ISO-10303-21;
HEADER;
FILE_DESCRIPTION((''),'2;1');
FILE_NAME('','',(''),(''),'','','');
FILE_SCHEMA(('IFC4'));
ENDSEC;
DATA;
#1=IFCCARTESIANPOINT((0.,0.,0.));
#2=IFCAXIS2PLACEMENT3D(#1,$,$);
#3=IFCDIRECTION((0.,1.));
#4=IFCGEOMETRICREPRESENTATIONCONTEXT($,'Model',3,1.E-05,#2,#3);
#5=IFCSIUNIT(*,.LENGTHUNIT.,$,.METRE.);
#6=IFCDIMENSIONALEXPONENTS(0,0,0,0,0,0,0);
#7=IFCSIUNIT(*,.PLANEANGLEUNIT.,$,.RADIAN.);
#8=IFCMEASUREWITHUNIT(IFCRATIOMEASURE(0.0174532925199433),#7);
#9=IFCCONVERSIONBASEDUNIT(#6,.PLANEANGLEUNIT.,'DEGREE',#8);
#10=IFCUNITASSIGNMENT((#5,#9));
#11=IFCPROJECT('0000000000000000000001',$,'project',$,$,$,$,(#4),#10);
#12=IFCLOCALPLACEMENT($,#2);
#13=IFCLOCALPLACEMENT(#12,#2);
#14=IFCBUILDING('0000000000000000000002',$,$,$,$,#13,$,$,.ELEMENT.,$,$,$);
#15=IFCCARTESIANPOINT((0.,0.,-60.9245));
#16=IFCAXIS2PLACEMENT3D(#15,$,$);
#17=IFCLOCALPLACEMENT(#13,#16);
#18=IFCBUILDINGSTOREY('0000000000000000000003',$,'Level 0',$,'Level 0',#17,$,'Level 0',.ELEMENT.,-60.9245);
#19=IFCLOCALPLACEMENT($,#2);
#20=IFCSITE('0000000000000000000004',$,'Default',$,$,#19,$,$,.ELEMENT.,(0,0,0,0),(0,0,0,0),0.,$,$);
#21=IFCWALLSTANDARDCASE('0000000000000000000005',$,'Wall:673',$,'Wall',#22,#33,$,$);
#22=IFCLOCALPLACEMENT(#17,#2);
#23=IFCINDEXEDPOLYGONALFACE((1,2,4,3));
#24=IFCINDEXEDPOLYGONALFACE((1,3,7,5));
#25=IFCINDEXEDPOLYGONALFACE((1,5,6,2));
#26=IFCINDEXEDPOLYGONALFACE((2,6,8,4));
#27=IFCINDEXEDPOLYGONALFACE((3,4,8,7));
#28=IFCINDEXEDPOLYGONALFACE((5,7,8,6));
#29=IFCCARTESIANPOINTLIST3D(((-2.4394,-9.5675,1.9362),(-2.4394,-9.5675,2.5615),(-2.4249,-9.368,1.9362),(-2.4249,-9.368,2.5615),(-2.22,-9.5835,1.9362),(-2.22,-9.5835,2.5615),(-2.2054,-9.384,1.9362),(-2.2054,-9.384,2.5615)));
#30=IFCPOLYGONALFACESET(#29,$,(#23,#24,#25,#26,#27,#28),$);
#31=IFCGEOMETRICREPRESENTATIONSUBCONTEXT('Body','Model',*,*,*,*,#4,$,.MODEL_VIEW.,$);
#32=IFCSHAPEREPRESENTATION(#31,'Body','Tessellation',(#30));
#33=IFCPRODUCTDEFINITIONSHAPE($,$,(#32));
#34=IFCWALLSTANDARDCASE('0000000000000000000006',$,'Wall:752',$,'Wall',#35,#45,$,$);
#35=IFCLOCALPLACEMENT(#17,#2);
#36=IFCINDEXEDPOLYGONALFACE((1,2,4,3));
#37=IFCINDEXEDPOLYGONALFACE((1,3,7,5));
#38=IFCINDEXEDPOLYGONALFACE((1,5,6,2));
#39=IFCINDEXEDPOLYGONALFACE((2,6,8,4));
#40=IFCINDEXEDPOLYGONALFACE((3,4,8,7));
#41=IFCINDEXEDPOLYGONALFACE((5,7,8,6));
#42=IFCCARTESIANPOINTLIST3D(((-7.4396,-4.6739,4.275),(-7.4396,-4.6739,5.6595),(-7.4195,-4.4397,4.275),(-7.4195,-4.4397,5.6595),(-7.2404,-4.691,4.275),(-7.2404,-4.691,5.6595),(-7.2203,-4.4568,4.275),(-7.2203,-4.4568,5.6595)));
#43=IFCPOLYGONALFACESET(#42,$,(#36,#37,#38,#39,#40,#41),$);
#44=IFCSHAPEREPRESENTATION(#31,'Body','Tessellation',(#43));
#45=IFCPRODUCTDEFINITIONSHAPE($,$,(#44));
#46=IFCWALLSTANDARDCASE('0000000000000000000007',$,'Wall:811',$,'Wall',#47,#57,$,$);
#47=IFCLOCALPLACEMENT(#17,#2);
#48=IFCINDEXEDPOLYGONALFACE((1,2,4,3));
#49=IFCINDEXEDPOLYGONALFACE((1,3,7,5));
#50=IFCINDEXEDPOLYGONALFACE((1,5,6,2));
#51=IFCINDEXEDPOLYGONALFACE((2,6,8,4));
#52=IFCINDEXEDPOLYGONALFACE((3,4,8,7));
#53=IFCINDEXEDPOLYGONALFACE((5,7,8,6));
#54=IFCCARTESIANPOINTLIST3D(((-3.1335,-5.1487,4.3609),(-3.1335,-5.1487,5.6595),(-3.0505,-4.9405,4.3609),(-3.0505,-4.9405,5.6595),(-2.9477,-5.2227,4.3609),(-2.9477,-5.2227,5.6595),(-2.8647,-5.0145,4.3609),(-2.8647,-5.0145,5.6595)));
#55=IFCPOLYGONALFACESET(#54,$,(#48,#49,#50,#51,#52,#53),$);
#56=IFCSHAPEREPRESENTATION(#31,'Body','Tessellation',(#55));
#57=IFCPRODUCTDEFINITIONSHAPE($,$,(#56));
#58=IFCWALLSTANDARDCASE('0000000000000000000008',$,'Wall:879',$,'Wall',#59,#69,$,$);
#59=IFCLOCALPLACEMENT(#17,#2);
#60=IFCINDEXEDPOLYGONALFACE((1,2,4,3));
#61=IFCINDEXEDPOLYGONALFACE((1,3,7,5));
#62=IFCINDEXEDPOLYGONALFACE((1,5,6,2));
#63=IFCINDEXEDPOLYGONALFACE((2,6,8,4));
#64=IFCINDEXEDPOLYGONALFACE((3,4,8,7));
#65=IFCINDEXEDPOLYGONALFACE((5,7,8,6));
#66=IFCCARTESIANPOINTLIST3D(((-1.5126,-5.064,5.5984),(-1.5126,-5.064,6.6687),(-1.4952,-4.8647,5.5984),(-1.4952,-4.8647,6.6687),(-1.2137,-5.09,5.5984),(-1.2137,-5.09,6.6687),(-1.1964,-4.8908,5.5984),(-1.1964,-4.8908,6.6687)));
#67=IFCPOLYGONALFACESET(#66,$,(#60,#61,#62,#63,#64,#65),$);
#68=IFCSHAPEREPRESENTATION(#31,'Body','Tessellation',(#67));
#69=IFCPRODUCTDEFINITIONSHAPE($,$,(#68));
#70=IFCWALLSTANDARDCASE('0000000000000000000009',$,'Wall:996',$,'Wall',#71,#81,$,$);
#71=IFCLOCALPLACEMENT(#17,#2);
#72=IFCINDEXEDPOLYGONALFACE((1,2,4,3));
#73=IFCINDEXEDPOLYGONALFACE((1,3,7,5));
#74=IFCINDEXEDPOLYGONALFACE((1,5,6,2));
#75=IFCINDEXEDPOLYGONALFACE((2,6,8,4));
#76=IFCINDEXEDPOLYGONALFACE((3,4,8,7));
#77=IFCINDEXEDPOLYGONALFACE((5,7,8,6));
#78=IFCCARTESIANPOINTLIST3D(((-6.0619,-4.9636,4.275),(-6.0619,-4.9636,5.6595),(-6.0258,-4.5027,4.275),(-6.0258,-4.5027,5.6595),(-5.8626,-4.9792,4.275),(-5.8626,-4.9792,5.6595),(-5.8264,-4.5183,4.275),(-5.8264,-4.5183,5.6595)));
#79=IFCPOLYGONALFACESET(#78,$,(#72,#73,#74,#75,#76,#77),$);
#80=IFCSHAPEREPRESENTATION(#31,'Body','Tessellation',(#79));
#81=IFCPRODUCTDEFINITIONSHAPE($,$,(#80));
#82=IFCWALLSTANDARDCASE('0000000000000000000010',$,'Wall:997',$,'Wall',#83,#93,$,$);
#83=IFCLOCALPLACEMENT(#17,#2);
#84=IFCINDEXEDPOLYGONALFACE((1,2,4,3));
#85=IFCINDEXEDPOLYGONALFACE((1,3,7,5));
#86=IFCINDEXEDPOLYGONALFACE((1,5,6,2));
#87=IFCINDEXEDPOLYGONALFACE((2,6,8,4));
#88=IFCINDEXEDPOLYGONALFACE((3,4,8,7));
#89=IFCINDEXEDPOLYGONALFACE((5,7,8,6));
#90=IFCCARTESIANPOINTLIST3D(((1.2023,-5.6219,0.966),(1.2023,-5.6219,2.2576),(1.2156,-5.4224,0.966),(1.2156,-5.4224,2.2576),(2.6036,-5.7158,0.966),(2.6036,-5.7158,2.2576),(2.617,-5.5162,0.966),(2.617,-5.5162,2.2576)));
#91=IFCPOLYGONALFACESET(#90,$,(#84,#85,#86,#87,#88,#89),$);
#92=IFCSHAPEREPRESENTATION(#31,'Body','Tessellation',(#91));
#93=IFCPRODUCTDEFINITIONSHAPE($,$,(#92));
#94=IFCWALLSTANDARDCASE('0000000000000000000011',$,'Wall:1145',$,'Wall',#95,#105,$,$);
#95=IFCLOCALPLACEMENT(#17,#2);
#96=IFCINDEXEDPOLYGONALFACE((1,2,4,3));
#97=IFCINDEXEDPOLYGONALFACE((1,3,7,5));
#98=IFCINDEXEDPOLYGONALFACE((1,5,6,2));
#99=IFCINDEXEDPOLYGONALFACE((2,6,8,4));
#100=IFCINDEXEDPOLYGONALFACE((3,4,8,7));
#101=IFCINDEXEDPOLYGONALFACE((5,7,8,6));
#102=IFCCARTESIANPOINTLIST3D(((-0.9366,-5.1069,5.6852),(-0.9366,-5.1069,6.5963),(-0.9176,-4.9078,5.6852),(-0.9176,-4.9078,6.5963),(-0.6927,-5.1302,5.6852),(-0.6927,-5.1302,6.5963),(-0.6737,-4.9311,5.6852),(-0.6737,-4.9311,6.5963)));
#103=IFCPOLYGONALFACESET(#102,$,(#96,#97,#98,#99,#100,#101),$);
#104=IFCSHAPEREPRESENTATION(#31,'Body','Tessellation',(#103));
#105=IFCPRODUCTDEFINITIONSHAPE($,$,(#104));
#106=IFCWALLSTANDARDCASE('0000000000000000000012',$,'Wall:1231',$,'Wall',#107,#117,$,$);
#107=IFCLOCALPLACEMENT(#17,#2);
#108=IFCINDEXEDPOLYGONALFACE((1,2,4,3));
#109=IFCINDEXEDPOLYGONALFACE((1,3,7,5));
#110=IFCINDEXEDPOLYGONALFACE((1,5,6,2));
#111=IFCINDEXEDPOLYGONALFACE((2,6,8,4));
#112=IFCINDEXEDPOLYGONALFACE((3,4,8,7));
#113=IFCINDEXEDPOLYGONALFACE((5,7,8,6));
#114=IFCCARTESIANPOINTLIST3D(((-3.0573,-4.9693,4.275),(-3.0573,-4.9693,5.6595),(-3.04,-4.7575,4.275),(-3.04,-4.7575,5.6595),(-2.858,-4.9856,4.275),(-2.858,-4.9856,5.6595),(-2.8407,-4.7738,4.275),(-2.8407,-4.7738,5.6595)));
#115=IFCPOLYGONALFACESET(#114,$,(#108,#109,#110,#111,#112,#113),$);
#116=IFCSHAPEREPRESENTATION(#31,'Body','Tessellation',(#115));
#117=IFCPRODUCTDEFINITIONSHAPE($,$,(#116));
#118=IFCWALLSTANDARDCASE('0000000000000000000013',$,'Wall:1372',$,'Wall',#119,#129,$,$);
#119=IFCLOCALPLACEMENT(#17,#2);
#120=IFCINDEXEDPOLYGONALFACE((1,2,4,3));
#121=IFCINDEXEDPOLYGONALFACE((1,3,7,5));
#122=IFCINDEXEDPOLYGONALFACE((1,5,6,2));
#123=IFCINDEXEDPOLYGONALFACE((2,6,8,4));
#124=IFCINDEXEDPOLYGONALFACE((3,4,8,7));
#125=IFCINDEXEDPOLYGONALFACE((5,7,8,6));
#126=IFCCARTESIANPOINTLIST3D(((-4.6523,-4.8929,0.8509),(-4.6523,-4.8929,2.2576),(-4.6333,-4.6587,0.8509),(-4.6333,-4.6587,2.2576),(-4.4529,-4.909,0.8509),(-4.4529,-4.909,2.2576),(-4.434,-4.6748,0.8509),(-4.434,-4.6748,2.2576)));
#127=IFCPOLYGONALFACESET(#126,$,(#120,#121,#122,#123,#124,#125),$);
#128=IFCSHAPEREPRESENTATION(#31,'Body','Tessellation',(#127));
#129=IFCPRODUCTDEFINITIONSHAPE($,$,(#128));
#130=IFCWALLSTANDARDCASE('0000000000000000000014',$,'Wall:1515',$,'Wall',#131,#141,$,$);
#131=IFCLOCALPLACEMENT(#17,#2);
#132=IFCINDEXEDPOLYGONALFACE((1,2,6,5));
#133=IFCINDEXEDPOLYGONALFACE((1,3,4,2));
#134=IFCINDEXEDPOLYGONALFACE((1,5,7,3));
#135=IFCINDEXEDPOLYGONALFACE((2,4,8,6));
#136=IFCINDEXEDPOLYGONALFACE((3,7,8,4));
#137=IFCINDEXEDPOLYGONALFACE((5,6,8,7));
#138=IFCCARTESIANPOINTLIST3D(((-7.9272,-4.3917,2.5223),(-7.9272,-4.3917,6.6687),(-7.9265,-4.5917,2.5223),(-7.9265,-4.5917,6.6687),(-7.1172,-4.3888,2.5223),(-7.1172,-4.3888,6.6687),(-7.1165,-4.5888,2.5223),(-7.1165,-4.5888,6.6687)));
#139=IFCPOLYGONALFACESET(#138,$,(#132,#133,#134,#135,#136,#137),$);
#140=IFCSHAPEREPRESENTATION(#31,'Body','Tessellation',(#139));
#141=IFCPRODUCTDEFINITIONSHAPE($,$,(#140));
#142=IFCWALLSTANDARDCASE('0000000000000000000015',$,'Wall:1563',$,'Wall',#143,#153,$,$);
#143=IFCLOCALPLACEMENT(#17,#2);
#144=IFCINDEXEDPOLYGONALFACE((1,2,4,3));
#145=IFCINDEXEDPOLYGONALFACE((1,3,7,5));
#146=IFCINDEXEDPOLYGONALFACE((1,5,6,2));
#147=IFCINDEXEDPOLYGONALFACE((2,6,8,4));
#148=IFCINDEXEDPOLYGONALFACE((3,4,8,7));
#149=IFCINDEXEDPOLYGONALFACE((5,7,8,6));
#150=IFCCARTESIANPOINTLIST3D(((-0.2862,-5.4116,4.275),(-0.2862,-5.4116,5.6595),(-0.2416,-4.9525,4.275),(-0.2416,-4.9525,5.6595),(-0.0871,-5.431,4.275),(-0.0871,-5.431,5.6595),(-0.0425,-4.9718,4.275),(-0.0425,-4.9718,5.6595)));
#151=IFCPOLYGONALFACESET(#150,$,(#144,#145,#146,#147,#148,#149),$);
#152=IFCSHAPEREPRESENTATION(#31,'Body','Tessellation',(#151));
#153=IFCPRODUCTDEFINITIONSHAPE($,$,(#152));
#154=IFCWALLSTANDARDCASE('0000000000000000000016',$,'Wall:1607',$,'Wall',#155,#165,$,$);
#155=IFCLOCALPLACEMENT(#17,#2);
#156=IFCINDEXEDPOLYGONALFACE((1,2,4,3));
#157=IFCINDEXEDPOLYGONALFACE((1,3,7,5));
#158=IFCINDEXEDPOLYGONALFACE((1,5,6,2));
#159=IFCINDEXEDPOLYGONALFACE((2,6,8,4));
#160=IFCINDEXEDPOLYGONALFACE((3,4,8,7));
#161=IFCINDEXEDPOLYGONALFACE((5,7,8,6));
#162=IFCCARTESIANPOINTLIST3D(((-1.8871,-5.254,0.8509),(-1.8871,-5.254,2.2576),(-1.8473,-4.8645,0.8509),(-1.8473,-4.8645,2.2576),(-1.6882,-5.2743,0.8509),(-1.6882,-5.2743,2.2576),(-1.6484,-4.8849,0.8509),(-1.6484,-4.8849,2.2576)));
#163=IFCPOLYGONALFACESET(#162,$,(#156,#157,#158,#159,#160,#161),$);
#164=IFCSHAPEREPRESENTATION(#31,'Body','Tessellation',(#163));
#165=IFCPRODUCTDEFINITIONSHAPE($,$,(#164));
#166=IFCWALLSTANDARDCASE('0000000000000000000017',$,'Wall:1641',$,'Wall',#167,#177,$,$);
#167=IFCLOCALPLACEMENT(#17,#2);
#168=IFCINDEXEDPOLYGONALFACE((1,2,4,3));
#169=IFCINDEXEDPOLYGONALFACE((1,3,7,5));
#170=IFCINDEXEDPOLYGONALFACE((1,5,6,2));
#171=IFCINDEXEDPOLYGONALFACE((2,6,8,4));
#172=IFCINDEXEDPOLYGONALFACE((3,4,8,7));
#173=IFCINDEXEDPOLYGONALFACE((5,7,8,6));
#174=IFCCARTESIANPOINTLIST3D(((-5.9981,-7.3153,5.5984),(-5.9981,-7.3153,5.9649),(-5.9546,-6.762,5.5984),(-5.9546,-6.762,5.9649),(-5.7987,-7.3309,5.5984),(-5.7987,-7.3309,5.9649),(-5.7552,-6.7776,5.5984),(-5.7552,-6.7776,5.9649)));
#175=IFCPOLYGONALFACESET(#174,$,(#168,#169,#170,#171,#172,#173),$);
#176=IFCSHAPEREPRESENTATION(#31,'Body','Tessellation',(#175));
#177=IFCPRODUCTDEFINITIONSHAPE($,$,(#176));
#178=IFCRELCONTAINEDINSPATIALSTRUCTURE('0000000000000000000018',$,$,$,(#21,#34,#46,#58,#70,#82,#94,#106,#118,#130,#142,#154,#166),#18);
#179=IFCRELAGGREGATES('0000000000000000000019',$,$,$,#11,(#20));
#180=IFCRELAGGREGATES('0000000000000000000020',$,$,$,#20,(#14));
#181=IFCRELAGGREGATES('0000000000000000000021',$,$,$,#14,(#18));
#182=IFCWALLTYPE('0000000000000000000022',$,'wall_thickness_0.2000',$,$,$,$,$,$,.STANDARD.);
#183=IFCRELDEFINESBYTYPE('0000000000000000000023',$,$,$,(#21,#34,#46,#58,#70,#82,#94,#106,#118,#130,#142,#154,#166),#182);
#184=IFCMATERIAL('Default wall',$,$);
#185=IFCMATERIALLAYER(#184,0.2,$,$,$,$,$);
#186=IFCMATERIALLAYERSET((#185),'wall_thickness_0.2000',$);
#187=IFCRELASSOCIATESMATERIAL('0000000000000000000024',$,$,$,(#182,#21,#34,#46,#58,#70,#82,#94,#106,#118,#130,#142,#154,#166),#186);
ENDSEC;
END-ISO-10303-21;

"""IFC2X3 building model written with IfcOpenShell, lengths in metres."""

from ifc_helpers import new_model, entity, si_unit, converted_unit, direction, frame, origin, place, context, subcontext, project, spatial, polyline, outline, extrude, material, layer, layer_set, layer_usage, type_object, element, save


model = new_model("IFC2X3")

# Units and contexts
model_context = context("Model", 3, precision=1e-05, world=origin(), true_north=direction((0.0, 1.0)))
body_context = subcontext(model_context, "Body", "Model", "MODEL_VIEW")
ifc_project = project(units=[si_unit("LENGTHUNIT", "METRE"), converted_unit("PLANEANGLEUNIT", "DEGREE", entity("IfcRatioMeasure", 0.0174532925199433), si_unit("PLANEANGLEUNIT", "RADIAN"), dimensions=[0, 0, 0, 0, 0, 0, 0])], contexts=[model_context])

# Site, building, storey
site_placement = place(None, origin())
site = spatial("IfcSite", under=ifc_project, at=site_placement, Name="Default", CompositionType="ELEMENT", RefLatitude=(0, 0, 0, 0), RefLongitude=(0, 0, 0, 0), RefElevation=0.0)
placement_1 = place(None, origin())
building_placement = place(placement_1, origin())
building = spatial("IfcBuilding", under=site, at=building_placement, CompositionType="ELEMENT")
storey_placement = place(building_placement, frame((0.0, 0.0, -60.9245)))
storey = spatial("IfcBuildingStorey", under=building, at=storey_placement, Name="Level 0", ObjectType="Level 0", LongName="Level 0", CompositionType="ELEMENT", Elevation=-60.9245)

# Shared definitions
ifc_material_1 = material(Name="Default wall")
ifc_layer = layer(ifc_material_1, 0.2)
ifc_layer_set = layer_set([ifc_layer], Name="wall_thickness_0.2000")
ifc_layer_usage = layer_usage(ifc_layer_set, "AXIS2", "POSITIVE", -0.1)
wall_type = type_object("IfcWallType", Name="wall_thickness_0.2000", PredefinedType="STANDARD", material=ifc_layer_set)

# Walls
placement_2 = place(building_placement, frame((0.0, 0.0, -58.9883)))
wall_1_placement = place(placement_2, frame((-2.2127, -9.4838, 0.0), z_axis=(0.0, 0.0, 1.0), x_axis=(-0.997357, 0.072661, 0.0)))
element("IfcWallStandardCase", 1, at=wall_1_placement, inside=storey, type_object=wall_type, material=ifc_layer_usage, Name="Wall:673", ObjectType="Wall", context=body_context, shape_type="SweptSolid", body=[
    extrude(outline(polyline([(0.22, -0.1), (0.22, 0.1), (0.0, 0.1), (0.0, -0.1), (0.22, -0.1)])), origin(), (0.0, 0.0, 1.0), 0.6253),
])
placement_3 = place(building_placement, frame((0.0, 0.0, -56.6495)))
wall_2_placement = place(placement_3, frame((-7.3199, -4.4483, 0.0), z_axis=(0.0, 0.0, 1.0), x_axis=(-0.085445, -0.996343, 0.0)))
element("IfcWallStandardCase", 2, at=wall_2_placement, inside=storey, type_object=wall_type, material=ifc_layer_usage, Name="Wall:752", ObjectType="Wall", context=body_context, shape_type="SweptSolid", body=[
    extrude(outline(polyline([(0.235, -0.1), (0.235, 0.1), (0.0, 0.1), (0.0, -0.1), (0.235, -0.1)])), origin(), (0.0, 0.0, 1.0), 1.3845),
])
placement_4 = place(building_placement, frame((0.0, 0.0, -56.5636)))
wall_3_placement = place(placement_4, frame((-3.0406, -5.1857, 0.0), z_axis=(0.0, 0.0, 1.0), x_axis=(0.370155, 0.92897, 0.0)))
element("IfcWallStandardCase", 3, at=wall_3_placement, inside=storey, type_object=wall_type, material=ifc_layer_usage, Name="Wall:811", ObjectType="Wall", context=body_context, shape_type="SweptSolid", body=[
    extrude(outline(polyline([(0.2241, -0.1), (0.2241, 0.1), (0.0, 0.1), (0.0, -0.1), (0.2241, -0.1)])), origin(), (0.0, 0.0, 1.0), 1.2985),
])
placement_5 = place(building_placement, frame((0.0, 0.0, -55.3261)))
wall_4_placement = place(placement_5, frame((-1.205, -4.9904, 0.0), z_axis=(0.0, 0.0, 1.0), x_axis=(-0.996227, 0.086791, 0.0)))
element("IfcWallStandardCase", 4, at=wall_4_placement, inside=storey, type_object=wall_type, material=ifc_layer_usage, Name="Wall:879", ObjectType="Wall", context=body_context, shape_type="SweptSolid", body=[
    extrude(outline(polyline([(0.3, -0.1), (0.3, 0.1), (0.0, 0.1), (0.0, -0.1), (0.3, -0.1)])), origin(), (0.0, 0.0, 1.0), 1.0703),
])
placement_6 = place(building_placement, frame((0.0, 0.0, -56.6495)))
wall_5_placement = place(placement_6, frame((-5.9261, -4.5105, 0.0), z_axis=(0.0, 0.0, 1.0), x_axis=(-0.078166, -0.99694, 0.0)))
element("IfcWallStandardCase", 5, at=wall_5_placement, inside=storey, type_object=wall_type, material=ifc_layer_usage, Name="Wall:996", ObjectType="Wall", context=body_context, shape_type="SweptSolid", body=[
    extrude(outline(polyline([(0.4623, -0.1), (0.4623, 0.1), (0.0, 0.1), (0.0, -0.1), (0.4623, -0.1)])), origin(), (0.0, 0.0, 1.0), 1.3845),
])
placement_7 = place(building_placement, frame((0.0, 0.0, -59.9585)))
wall_6_placement = place(placement_7, frame((2.6103, -5.616, 0.0), z_axis=(0.0, 0.0, 1.0), x_axis=(-0.997764, 0.066831, 0.0)))
element("IfcWallStandardCase", 6, at=wall_6_placement, inside=storey, type_object=wall_type, material=ifc_layer_usage, Name="Wall:997", ObjectType="Wall", context=body_context, shape_type="SweptSolid", body=[
    extrude(outline(polyline([(1.4045, -0.1), (1.4045, 0.1), (0.0, 0.1), (0.0, -0.1), (1.4045, -0.1)])), origin(), (0.0, 0.0, 1.0), 1.2916),
])
placement_8 = place(building_placement, frame((0.0, 0.0, -55.2393)))
wall_7_placement = place(placement_8, frame((-0.6832, -5.0306, 0.0), z_axis=(0.0, 0.0, 1.0), x_axis=(-0.995487, 0.094902, 0.0)))
element("IfcWallStandardCase", 7, at=wall_7_placement, inside=storey, type_object=wall_type, material=ifc_layer_usage, Name="Wall:1145", ObjectType="Wall", context=body_context, shape_type="SweptSolid", body=[
    extrude(outline(polyline([(0.245, -0.1), (0.245, 0.1), (0.0, 0.1), (0.0, -0.1), (0.245, -0.1)])), origin(), (0.0, 0.0, 1.0), 0.9111),
])
placement_9 = place(building_placement, frame((0.0, 0.0, -56.6495)))
wall_8_placement = place(placement_9, frame((-2.9403, -4.7656, 0.0), z_axis=(0.0, 0.0, 1.0), x_axis=(-0.081346, -0.996686, 0.0)))
element("IfcWallStandardCase", 8, at=wall_8_placement, inside=storey, type_object=wall_type, material=ifc_layer_usage, Name="Wall:1231", ObjectType="Wall", context=body_context, shape_type="SweptSolid", body=[
    extrude(outline(polyline([(0.2125, -0.1), (0.2125, 0.1), (0.0, 0.1), (0.0, -0.1), (0.2125, -0.1)])), origin(), (0.0, 0.0, 1.0), 1.3845),
])
placement_10 = place(building_placement, frame((0.0, 0.0, -60.0736)))
wall_9_placement = place(placement_10, frame((-4.5336, -4.6667, 0.0), z_axis=(0.0, 0.0, 1.0), x_axis=(-0.080691, -0.996739, 0.0)))
element("IfcWallStandardCase", 9, at=wall_9_placement, inside=storey, type_object=wall_type, material=ifc_layer_usage, Name="Wall:1372", ObjectType="Wall", context=body_context, shape_type="SweptSolid", body=[
    extrude(outline(polyline([(0.235, -0.1), (0.235, 0.1), (0.0, 0.1), (0.0, -0.1), (0.235, -0.1)])), origin(), (0.0, 0.0, 1.0), 1.4068),
])
placement_11 = place(building_placement, frame((0.0, 0.0, -58.4022)))
wall_10_placement = place(placement_11, frame((-7.1168, -4.4888, 0.0), z_axis=(0.0, 0.0, 1.0), x_axis=(-0.999994, -0.003584, 0.0)))
element("IfcWallStandardCase", 10, at=wall_10_placement, inside=storey, type_object=wall_type, material=ifc_layer_usage, Name="Wall:1515", ObjectType="Wall", context=body_context, shape_type="SweptSolid", body=[
    extrude(outline(polyline([(0.81, -0.1), (0.81, 0.1), (0.0, 0.1), (0.0, -0.1), (0.81, -0.1)])), origin(), (0.0, 0.0, 1.0), 4.1464),
])
placement_12 = place(building_placement, frame((0.0, 0.0, -56.6495)))
wall_11_placement = place(placement_12, frame((-0.1866, -5.4213, 0.0), z_axis=(0.0, 0.0, 1.0), x_axis=(0.096662, 0.995317, 0.0)))
element("IfcWallStandardCase", 11, at=wall_11_placement, inside=storey, type_object=wall_type, material=ifc_layer_usage, Name="Wall:1563", ObjectType="Wall", context=body_context, shape_type="SweptSolid", body=[
    extrude(outline(polyline([(0.4613, -0.1), (0.4613, 0.1), (0.0, 0.1), (0.0, -0.1), (0.4613, -0.1)])), origin(), (0.0, 0.0, 1.0), 1.3845),
])
placement_13 = place(building_placement, frame((0.0, 0.0, -60.0736)))
wall_12_placement = place(placement_13, frame((-1.7877, -5.2641, 0.0), z_axis=(0.0, 0.0, 1.0), x_axis=(0.10173, 0.994812, 0.0)))
element("IfcWallStandardCase", 12, at=wall_12_placement, inside=storey, type_object=wall_type, material=ifc_layer_usage, Name="Wall:1607", ObjectType="Wall", context=body_context, shape_type="SweptSolid", body=[
    extrude(outline(polyline([(0.3915, -0.1), (0.3915, 0.1), (0.0, 0.1), (0.0, -0.1), (0.3915, -0.1)])), origin(), (0.0, 0.0, 1.0), 1.4068),
])
placement_14 = place(building_placement, frame((0.0, 0.0, -55.3261)))
wall_13_placement = place(placement_14, frame((-5.8984, -7.3231, 0.0), z_axis=(0.0, 0.0, 1.0), x_axis=(0.078321, 0.996928, 0.0)))
element("IfcWallStandardCase", 13, at=wall_13_placement, inside=storey, type_object=wall_type, material=ifc_layer_usage, Name="Wall:1641", ObjectType="Wall", context=body_context, shape_type="SweptSolid", body=[
    extrude(outline(polyline([(0.555, -0.1), (0.555, 0.1), (0.0, 0.1), (0.0, -0.1), (0.555, -0.1)])), origin(), (0.0, 0.0, 1.0), 0.3666),
])

save(model, "model.ifc")
